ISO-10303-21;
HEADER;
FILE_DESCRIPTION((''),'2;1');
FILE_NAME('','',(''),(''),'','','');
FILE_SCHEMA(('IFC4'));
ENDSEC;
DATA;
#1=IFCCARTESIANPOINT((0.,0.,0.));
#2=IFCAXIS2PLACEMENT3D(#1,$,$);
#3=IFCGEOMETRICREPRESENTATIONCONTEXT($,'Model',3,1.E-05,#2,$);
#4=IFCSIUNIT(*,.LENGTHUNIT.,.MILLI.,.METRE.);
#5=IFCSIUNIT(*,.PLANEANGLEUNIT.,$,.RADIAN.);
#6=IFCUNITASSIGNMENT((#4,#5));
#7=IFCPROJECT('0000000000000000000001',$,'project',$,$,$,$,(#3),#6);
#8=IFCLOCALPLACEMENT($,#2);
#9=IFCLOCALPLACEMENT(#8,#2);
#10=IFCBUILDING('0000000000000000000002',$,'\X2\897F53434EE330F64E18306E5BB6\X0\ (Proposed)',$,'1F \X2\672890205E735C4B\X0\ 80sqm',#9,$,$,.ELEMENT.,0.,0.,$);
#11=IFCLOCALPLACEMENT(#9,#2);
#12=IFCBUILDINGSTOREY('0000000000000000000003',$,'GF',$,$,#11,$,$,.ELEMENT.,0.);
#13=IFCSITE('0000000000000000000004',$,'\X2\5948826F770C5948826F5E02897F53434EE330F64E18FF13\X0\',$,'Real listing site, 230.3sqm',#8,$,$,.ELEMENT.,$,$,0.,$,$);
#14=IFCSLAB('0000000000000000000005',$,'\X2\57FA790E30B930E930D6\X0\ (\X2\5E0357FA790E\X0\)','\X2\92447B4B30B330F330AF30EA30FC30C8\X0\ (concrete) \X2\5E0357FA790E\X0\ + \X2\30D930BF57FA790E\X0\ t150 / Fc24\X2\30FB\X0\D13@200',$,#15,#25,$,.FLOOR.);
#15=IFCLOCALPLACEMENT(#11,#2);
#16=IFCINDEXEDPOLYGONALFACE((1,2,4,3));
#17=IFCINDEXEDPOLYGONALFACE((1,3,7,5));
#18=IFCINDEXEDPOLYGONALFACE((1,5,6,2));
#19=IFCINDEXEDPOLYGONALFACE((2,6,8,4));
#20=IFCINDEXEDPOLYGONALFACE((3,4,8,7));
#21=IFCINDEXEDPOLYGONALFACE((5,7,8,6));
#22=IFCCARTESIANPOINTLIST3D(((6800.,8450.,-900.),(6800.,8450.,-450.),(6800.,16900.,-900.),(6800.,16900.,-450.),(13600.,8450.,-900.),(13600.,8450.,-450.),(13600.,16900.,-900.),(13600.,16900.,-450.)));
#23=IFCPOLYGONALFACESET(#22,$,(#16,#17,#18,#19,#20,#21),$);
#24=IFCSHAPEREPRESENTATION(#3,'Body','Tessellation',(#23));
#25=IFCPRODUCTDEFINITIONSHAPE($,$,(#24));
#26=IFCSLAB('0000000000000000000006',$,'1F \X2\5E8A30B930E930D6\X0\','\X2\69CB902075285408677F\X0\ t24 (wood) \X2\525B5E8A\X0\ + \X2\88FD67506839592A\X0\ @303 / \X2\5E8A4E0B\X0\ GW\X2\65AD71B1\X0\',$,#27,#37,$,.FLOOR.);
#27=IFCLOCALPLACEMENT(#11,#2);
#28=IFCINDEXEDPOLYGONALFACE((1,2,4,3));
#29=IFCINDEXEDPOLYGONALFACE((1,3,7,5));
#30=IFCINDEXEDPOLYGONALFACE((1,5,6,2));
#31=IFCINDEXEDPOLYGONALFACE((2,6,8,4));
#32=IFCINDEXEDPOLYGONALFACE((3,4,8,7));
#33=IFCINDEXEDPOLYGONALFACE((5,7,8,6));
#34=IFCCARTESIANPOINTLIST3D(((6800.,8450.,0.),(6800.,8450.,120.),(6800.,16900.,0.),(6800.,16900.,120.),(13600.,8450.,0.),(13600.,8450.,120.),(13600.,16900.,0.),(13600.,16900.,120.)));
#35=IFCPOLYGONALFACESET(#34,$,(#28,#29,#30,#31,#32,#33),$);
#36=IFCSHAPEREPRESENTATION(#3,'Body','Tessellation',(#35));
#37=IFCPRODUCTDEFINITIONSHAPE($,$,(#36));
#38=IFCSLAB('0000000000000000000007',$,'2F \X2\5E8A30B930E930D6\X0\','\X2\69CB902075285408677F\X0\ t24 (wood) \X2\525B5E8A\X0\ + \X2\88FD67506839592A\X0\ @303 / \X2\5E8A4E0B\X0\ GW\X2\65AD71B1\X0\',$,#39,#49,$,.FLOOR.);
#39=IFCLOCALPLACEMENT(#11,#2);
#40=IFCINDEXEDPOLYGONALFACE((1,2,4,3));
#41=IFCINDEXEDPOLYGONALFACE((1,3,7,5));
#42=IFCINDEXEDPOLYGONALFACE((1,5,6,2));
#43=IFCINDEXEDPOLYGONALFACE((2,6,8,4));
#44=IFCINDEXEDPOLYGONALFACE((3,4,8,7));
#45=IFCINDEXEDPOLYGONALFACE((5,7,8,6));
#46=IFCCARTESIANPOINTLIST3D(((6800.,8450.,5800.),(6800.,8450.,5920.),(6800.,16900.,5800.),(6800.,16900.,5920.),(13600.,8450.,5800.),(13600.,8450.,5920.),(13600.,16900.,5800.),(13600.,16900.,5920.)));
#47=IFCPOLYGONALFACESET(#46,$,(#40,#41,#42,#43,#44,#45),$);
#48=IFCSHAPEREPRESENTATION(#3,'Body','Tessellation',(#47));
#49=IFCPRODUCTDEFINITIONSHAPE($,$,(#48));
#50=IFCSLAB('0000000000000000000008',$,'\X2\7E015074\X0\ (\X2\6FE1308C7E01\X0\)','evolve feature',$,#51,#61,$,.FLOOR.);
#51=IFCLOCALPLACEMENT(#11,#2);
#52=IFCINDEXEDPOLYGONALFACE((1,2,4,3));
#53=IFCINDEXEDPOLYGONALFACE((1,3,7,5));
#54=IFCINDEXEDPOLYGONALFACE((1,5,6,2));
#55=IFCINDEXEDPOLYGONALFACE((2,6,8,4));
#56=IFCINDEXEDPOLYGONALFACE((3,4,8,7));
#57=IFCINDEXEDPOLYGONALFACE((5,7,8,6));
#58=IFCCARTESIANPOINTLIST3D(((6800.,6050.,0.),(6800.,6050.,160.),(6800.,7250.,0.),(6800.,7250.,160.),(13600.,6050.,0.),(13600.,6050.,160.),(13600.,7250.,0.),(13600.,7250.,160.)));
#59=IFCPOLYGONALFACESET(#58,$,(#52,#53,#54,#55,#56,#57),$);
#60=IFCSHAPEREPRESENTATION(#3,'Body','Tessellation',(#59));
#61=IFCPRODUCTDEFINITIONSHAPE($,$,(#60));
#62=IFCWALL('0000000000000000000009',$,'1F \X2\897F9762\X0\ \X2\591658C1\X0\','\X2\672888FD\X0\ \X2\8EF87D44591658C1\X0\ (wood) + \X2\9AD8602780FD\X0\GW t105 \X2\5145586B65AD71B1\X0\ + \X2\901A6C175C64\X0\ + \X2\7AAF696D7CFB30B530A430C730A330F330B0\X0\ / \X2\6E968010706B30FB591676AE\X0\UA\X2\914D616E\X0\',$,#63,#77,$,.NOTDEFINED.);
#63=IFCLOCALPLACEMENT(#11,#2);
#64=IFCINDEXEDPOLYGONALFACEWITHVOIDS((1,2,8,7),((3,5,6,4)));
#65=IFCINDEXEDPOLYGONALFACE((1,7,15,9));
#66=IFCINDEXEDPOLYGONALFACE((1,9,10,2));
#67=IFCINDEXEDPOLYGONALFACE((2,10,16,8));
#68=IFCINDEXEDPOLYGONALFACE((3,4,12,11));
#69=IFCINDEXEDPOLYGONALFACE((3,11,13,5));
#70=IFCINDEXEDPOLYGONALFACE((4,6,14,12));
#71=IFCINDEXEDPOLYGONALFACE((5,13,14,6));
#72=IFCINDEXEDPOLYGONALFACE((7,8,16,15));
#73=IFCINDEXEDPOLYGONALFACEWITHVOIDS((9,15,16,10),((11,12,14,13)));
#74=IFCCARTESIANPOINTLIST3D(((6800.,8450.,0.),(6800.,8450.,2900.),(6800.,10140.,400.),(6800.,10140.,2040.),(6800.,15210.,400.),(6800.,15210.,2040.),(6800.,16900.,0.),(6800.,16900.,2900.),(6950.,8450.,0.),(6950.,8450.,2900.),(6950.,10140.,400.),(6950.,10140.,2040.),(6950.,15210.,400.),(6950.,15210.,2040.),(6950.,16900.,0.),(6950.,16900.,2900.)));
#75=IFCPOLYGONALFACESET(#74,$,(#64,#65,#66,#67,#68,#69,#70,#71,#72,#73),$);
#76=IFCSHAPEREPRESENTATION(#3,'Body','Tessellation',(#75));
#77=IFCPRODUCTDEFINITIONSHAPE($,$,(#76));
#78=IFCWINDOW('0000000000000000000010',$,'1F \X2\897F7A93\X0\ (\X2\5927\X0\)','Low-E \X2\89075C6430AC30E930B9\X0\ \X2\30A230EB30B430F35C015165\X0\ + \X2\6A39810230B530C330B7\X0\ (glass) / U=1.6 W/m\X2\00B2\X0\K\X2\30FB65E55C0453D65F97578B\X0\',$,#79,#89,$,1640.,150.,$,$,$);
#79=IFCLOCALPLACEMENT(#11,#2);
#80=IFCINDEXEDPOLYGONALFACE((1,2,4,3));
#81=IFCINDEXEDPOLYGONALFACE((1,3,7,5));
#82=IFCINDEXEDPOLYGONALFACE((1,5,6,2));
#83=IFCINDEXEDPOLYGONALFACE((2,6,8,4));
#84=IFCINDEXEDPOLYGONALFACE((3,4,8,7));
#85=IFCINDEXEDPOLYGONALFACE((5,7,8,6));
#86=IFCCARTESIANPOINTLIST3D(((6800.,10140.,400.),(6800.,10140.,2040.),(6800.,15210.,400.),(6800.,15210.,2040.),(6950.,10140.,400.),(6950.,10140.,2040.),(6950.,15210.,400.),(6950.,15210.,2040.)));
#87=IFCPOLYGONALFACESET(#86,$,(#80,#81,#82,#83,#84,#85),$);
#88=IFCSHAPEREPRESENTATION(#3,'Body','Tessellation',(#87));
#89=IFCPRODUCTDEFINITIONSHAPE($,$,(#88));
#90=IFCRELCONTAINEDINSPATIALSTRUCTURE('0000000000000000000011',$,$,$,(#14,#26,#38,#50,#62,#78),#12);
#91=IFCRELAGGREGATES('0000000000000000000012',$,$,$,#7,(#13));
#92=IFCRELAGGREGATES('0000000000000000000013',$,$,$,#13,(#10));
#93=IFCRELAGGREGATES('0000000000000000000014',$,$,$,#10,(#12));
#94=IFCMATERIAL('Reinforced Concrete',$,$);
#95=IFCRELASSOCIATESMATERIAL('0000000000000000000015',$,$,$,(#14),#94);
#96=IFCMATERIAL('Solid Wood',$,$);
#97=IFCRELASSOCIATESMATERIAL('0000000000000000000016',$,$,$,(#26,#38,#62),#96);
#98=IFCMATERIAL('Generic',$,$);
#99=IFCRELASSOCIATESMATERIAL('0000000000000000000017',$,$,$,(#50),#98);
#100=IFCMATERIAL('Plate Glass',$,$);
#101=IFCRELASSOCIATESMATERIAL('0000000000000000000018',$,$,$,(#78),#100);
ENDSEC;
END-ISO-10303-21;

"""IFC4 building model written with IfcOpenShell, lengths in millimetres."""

from ifc_helpers import new_model, si_unit, frame, frame_2d, origin, place, context, project, spatial, rectangle, extrude, material, element, fill, save


model = new_model("IFC4")

# Units and contexts
model_context = context("Model", 3, precision=1e-05, world=origin())
ifc_project = project(units=[si_unit("LENGTHUNIT", "METRE", prefix="MILLI"), si_unit("PLANEANGLEUNIT", "RADIAN")], contexts=[model_context])

# Site, building, storey
site_placement = place(None, origin())
site = spatial("IfcSite", under=ifc_project, at=site_placement, Name="奈良県奈良市西千代ヶ丘３", ObjectType="Real listing site, 230.3sqm", CompositionType="ELEMENT", RefElevation=0.0)
building_placement = place(site_placement, origin())
building = spatial("IfcBuilding", under=site, at=building_placement, Name="西千代ヶ丘の家 (Proposed)", ObjectType="1F 木造平屋 80sqm", CompositionType="ELEMENT", ElevationOfRefHeight=0.0, ElevationOfTerrain=0.0)
storey_placement = place(building_placement, origin())
storey = spatial("IfcBuildingStorey", under=building, at=storey_placement, Name="GF", CompositionType="ELEMENT", Elevation=0.0)

# Slabs
ifc_material_1 = material(Name="Reinforced Concrete")
slab_1_placement = place(storey_placement, frame((3400.0, 4225.0, -450.0)))
element("IfcSlab", 1, at=slab_1_placement, inside=storey, material=ifc_material_1, Name="基礎スラブ (布基礎)", Description="鉄筋コンクリート (concrete) 布基礎 + ベタ基礎 t150 / Fc24・D13@200", PredefinedType="FLOOR", context=model_context, shape_type="SweptSolid", body=[
    extrude(rectangle(XDim=6800.0, YDim=8450.0, at=frame_2d((3400.0, 4225.0))), frame((3400.0, 4225.0, -450.0)), (0.0, 0.0, 1.0), 450.0),
])
ifc_material_2 = material(Name="Solid Wood")
slab_2_placement = place(storey_placement, frame((3400.0, 4225.0, 0.0)))
element("IfcSlab", 2, at=slab_2_placement, inside=storey, material=ifc_material_2, Name="1F 床スラブ", Description="構造用合板 t24 (wood) 剛床 + 製材根太 @303 / 床下 GW断熱", PredefinedType="FLOOR", context=model_context, shape_type="SweptSolid", body=[
    extrude(rectangle(XDim=6800.0, YDim=8450.0, at=frame_2d((3400.0, 4225.0))), frame((3400.0, 4225.0, 0.0)), (0.0, 0.0, 1.0), 120.0),
])
slab_3_placement = place(storey_placement, frame((3400.0, 4225.0, 2900.0)))
element("IfcSlab", 3, at=slab_3_placement, inside=storey, material=ifc_material_2, Name="2F 床スラブ", Description="構造用合板 t24 (wood) 剛床 + 製材根太 @303 / 床下 GW断熱", PredefinedType="FLOOR", context=model_context, shape_type="SweptSolid", body=[
    extrude(rectangle(XDim=6800.0, YDim=8450.0, at=frame_2d((3400.0, 4225.0))), frame((3400.0, 4225.0, 2900.0)), (0.0, 0.0, 1.0), 120.0),
])
ifc_material_3 = material(Name="Generic")
slab_4_placement = place(storey_placement, frame((3400.0, 3025.0, 0.0)))
element("IfcSlab", 4, at=slab_4_placement, inside=storey, material=ifc_material_3, Name="縁側 (濡れ縁)", Description="evolve feature", PredefinedType="FLOOR", context=model_context, shape_type="SweptSolid", body=[
    extrude(rectangle(XDim=6800.0, YDim=1200.0, at=frame_2d((3400.0, 600.0))), frame((3400.0, 3025.0, 0.0)), (0.0, 0.0, 1.0), 160.0),
])

# Shared definitions
ifc_material_4 = material(Name="Plate Glass")

# Wall, opening, window
wall_1_placement = place(storey_placement, frame((3400.0, 4225.0, 0.0)))
wall_1 = element("IfcWall", 5, at=wall_1_placement, inside=storey, material=ifc_material_2, Name="1F 西面 外壁", Description="木製 軸組外壁 (wood) + 高性能GW t105 充填断熱 + 通気層 + 窯業系サイディング / 準耐火・外皮UA配慮", PredefinedType="NOTDEFINED", context=model_context, shape_type="SweptSolid", body=[
    extrude(rectangle(XDim=150.0, YDim=8450.0, at=frame_2d((75.0, 4225.0))), frame((3400.0, 4225.0, 0.0)), (0.0, 0.0, 1.0), 2900.0),
])
opening_1_placement = place(storey_placement, frame((3400.0, 5070.0, 200.0)))
opening_1 = element("IfcOpeningElement", 6, at=opening_1_placement, cuts=wall_1, PredefinedType="NOTDEFINED", context=model_context, shape_type="SweptSolid", body=[
    extrude(rectangle(XDim=150.0, YDim=5070.0, at=frame_2d((75.0, 2535.0))), frame((3400.0, 5070.0, 200.0)), (0.0, 0.0, 1.0), 1640.0),
])
window_1_placement = place(storey_placement, frame((3400.0, 5070.0, 200.0)))
window_1 = element("IfcWindow", 7, at=window_1_placement, inside=storey, material=ifc_material_4, Name="1F 西窓 (大)", Description="Low-E 複層ガラス アルゴン封入 + 樹脂サッシ (glass) / U=1.6 W/m²K・日射取得型", OverallHeight=1640.0, OverallWidth=150.0, context=model_context, shape_type="SweptSolid", body=[
    extrude(rectangle(XDim=150.0, YDim=5070.0, at=frame_2d((75.0, 2535.0))), frame((3400.0, 5070.0, 200.0)), (0.0, 0.0, 1.0), 1640.0),
])
fill(opening_1, window_1)

save(model, "model.ifc")
